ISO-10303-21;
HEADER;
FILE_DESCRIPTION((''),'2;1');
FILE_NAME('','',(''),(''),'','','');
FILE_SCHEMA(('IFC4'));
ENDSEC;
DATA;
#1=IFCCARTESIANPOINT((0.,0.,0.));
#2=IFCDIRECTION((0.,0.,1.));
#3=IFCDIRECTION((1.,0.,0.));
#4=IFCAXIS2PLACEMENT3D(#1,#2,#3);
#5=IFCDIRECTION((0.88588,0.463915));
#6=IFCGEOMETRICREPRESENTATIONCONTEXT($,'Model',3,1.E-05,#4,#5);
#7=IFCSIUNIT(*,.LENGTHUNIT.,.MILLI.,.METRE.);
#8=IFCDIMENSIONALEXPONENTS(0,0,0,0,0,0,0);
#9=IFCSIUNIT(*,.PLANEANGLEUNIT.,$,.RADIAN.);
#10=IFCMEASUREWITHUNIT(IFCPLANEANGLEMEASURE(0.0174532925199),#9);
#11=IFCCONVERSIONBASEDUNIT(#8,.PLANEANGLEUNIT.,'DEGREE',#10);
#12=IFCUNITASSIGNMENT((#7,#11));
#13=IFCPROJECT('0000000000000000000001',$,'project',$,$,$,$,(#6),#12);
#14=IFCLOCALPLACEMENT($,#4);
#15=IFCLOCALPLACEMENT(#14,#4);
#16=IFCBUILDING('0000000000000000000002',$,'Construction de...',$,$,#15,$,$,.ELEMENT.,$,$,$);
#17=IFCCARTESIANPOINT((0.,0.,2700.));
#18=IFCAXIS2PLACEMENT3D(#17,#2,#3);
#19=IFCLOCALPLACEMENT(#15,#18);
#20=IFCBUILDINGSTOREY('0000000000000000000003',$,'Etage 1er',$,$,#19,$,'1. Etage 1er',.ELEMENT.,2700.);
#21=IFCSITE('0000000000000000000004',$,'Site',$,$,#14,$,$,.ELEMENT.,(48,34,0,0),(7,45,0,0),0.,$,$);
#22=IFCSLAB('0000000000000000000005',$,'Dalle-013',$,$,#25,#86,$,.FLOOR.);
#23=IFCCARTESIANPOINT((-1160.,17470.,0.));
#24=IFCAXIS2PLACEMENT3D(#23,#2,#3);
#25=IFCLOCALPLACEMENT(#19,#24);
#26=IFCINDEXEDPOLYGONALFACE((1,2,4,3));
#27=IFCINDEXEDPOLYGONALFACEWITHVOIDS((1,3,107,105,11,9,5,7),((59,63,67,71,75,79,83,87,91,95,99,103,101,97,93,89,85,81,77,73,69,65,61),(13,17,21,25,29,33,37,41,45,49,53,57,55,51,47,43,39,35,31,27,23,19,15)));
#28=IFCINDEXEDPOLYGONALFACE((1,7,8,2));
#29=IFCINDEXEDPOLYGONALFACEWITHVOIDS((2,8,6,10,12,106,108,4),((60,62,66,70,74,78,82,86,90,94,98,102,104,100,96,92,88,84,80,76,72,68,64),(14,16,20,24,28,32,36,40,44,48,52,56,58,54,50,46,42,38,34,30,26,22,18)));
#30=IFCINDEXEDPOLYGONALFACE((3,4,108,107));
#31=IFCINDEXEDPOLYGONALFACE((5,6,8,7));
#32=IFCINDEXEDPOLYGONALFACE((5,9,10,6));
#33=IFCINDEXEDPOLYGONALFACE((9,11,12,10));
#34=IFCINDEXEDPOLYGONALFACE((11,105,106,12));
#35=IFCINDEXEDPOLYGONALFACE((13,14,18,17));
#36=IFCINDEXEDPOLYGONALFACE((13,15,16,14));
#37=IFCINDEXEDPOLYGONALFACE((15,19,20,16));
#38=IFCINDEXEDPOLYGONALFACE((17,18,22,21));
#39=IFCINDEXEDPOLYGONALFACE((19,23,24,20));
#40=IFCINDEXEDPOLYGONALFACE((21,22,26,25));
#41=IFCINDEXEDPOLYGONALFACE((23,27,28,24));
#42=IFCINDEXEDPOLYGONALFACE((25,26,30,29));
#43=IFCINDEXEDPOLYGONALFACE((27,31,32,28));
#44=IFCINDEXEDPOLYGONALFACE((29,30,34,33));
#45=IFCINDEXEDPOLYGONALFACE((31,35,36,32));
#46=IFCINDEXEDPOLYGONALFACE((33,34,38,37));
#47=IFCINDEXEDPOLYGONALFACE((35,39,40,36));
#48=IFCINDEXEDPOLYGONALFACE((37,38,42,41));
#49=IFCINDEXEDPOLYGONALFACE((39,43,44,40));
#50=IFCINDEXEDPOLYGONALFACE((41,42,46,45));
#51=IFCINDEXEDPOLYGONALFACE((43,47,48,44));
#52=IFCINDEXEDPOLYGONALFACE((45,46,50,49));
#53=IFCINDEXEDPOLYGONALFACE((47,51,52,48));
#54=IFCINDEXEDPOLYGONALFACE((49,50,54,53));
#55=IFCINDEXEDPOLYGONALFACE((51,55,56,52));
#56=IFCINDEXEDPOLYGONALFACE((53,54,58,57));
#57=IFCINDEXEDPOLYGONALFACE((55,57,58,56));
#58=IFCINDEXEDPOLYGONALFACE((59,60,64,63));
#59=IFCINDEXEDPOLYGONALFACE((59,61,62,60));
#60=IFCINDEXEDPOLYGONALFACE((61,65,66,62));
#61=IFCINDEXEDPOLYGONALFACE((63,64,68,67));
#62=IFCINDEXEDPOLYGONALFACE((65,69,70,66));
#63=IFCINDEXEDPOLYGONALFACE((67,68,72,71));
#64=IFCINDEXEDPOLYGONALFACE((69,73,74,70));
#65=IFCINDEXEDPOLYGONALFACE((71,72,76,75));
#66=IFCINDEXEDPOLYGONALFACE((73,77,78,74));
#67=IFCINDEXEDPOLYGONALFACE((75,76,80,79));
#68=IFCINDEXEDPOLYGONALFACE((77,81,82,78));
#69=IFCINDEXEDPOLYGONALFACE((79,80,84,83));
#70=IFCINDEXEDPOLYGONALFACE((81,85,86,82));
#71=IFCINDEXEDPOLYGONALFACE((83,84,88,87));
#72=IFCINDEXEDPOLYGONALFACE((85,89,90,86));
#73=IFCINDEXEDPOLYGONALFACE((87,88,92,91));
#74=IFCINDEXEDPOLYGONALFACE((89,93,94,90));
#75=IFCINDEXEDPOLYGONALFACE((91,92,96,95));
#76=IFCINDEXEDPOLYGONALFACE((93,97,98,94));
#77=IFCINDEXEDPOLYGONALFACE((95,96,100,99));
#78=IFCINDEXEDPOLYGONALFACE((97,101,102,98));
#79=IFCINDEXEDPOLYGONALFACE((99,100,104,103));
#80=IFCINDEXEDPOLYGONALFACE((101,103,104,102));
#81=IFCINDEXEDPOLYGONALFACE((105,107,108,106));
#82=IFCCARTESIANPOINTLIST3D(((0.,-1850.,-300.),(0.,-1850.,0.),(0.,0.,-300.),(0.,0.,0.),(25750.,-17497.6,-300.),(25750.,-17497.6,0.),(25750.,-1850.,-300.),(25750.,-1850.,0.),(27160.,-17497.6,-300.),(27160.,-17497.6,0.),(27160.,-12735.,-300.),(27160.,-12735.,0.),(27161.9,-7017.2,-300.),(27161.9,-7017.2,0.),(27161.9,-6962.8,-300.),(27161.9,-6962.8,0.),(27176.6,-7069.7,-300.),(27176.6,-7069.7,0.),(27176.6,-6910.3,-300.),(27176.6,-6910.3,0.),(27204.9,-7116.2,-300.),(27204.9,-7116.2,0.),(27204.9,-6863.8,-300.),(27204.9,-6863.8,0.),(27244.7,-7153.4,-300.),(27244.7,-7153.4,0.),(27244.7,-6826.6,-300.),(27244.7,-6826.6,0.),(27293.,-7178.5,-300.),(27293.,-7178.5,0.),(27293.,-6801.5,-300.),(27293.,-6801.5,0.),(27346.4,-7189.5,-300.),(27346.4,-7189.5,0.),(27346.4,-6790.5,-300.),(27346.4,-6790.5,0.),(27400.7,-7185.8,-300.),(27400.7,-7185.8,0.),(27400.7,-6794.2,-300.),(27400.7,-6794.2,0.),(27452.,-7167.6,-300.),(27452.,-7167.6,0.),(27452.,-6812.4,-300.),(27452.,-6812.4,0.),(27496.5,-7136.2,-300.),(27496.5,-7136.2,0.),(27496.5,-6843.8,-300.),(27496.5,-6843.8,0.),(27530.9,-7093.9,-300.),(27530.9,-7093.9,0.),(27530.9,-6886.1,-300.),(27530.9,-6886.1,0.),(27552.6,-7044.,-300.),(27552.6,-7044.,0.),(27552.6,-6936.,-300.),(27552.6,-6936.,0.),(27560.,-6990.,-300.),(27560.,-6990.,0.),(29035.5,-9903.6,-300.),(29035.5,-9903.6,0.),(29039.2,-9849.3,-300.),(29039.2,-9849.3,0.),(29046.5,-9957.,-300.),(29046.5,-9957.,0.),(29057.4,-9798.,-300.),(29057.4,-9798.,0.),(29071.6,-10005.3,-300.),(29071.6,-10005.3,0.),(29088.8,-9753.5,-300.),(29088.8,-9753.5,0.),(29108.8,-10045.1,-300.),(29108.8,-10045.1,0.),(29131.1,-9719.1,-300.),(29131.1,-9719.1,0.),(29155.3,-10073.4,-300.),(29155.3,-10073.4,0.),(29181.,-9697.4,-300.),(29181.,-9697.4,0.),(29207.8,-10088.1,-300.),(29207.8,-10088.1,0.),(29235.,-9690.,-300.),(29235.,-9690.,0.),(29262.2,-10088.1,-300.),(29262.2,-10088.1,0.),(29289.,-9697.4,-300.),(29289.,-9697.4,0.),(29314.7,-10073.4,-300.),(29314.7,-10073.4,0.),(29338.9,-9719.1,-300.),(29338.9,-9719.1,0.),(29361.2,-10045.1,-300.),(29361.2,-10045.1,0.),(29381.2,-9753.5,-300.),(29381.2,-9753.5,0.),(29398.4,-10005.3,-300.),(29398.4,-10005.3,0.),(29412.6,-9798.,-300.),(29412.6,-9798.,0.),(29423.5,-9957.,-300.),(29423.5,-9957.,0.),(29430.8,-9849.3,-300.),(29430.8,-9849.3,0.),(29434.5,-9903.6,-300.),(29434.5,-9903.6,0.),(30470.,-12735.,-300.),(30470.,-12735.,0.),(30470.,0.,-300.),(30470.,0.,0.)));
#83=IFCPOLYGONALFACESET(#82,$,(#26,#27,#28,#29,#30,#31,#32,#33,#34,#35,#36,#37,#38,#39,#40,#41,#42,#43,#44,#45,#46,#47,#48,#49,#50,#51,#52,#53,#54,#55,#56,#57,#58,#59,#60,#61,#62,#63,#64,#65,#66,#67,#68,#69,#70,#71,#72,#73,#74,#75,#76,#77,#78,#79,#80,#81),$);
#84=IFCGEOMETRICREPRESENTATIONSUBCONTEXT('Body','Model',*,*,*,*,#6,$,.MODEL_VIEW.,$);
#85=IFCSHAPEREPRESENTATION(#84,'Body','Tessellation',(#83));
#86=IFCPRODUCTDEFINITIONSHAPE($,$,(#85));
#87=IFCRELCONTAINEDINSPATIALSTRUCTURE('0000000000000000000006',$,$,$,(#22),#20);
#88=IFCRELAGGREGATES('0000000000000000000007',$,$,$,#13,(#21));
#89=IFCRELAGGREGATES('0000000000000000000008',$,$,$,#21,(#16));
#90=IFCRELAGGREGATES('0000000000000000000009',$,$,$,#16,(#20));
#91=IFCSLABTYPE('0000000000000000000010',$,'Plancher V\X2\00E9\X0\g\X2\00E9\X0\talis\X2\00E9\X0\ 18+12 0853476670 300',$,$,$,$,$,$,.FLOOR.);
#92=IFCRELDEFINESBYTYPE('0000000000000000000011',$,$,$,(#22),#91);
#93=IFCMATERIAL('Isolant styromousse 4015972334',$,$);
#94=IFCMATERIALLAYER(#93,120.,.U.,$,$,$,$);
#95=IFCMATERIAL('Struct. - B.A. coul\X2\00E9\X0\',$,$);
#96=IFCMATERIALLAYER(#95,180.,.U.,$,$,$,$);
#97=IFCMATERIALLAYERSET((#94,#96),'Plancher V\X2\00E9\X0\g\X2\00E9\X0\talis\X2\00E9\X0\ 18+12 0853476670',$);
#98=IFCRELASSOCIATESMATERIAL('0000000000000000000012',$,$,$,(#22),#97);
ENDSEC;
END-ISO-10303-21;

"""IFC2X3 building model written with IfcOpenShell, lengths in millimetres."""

from ifc_helpers import new_model, entity, si_unit, converted_unit, point, direction, frame, frame_2d, origin_with_axes, place, context, subcontext, project, spatial, polyline, circle_curve, parameter, trimmed, segment, composite_curve, outline, extrude, material, layer, layer_set, layer_usage, type_object, element, save


model = new_model("IFC2X3")

# Units and contexts
model_context = context("Model", 3, precision=1e-05, world=origin_with_axes(), true_north=direction((0.88588, 0.463915)))
body_context = subcontext(model_context, "Body", "Model", "MODEL_VIEW")
ifc_project = project(units=[si_unit("LENGTHUNIT", "METRE", prefix="MILLI"), converted_unit("PLANEANGLEUNIT", "DEGREE", entity("IfcPlaneAngleMeasure", 0.0174532925199), si_unit("PLANEANGLEUNIT", "RADIAN"), dimensions=[0, 0, 0, 0, 0, 0, 0])], contexts=[model_context])

# Site, building, storey
site_placement = place(None, origin_with_axes())
site = spatial("IfcSite", under=ifc_project, at=site_placement, Name="Site", CompositionType="ELEMENT", RefLatitude=(48, 34, 0, 0), RefLongitude=(7, 45, 0, 0), RefElevation=0.0)
building_placement = place(site_placement, origin_with_axes())
building = spatial("IfcBuilding", under=site, at=building_placement, Name="Construction de...", CompositionType="ELEMENT")
storey_placement = place(building_placement, frame((0.0, 0.0, 2700.0), z_axis=(0.0, 0.0, 1.0), x_axis=(1.0, 0.0, 0.0)))
storey = spatial("IfcBuildingStorey", under=building, at=storey_placement, Name="Etage 1er", LongName="1. Etage 1er", CompositionType="ELEMENT", Elevation=2700.0)

# Slab, openings
ifc_material_1 = material(Name="Isolant styromousse 4015972334")
ifc_layer_1 = layer(ifc_material_1, 120.0, ventilated="UNKNOWN")
ifc_material_2 = material(Name="Struct. - B.A. coulé")
ifc_layer_2 = layer(ifc_material_2, 180.0, ventilated="UNKNOWN")
ifc_layer_set_1 = layer_set([ifc_layer_1, ifc_layer_2], Name="Plancher Végétalisé 18+12 0853476670")
ifc_layer_usage_1 = layer_usage(ifc_layer_set_1, "AXIS3", "NEGATIVE", 300.0)
slab_type_1 = type_object("IfcSlabType", Name="Plancher Végétalisé 18+12 0853476670 300", PredefinedType="FLOOR")
slab_1_placement = place(storey_placement, frame((-1160.0, 17470.0, 0.0), z_axis=(0.0, 0.0, 1.0), x_axis=(1.0, 0.0, 0.0)))
slab_1 = element("IfcSlab", 1, at=slab_1_placement, inside=storey, type_object=slab_type_1, material=ifc_layer_usage_1, Name="Dalle-013", PredefinedType="FLOOR", context=body_context, shape_type="SweptSolid", body=[
    extrude(outline(polyline([(0.0, 0.0), (0.0, -1850.0), (25750.0, -1850.0), (25750.0, -17497.6), (27160.0, -17497.6), (27160.0, -12735.0), (30470.0, -12735.0), (30470.0, 0.0), (0.0, 0.0)])), frame((0.0, 0.0, -300.0), z_axis=(0.0, 0.0, 1.0), x_axis=(1.0, 0.0, 0.0)), (0.0, 0.0, 1.0), 300.0),
])
opening_1_placement = place(slab_1_placement, origin_with_axes())
element("IfcOpeningElement", 2, at=opening_1_placement, cuts=slab_1, context=body_context, shape_type="SweptSolid", body=[
    extrude(outline(composite_curve([segment(trimmed(circle_curve(frame_2d((27360.0, -6990.0), x_axis=(1.0, 0.0)), 200.0), [point((27560.0, -6990.0)), parameter(0.0)], [point((27360.0, -6790.0)), parameter(90.0)], True, "CARTESIAN"), True, "CONTINUOUS"), segment(trimmed(circle_curve(frame_2d((27360.0, -6990.0), x_axis=(0.0, 1.0)), 200.0), [point((27360.0, -6790.0)), parameter(0.0)], [point((27160.0, -6990.0)), parameter(90.0)], True, "CARTESIAN"), True, "CONTINUOUS"), segment(trimmed(circle_curve(frame_2d((27360.0, -6990.0), x_axis=(-1.0, 0.0)), 200.0), [point((27160.0, -6990.0)), parameter(0.0)], [point((27560.0, -6990.0)), parameter(180.0)], True, "CARTESIAN"), True, "CONTINUOUS")], self_intersect=False)), frame((0.0, 0.0, -300.0), z_axis=(0.0, 0.0, 1.0), x_axis=(1.0, 0.0, 0.0)), (0.0, 0.0, 1.0), 300.0),
])
opening_2_placement = place(slab_1_placement, origin_with_axes())
element("IfcOpeningElement", 3, at=opening_2_placement, cuts=slab_1, context=body_context, shape_type="SweptSolid", body=[
    extrude(outline(composite_curve([segment(trimmed(circle_curve(frame_2d((29235.0, -9890.0), x_axis=(-1.0, 0.0)), 200.0), [point((29035.0, -9890.0)), parameter(0.0)], [point((29435.0, -9890.0)), parameter(180.0)], True, "CARTESIAN"), True, "CONTINUOUS"), segment(trimmed(circle_curve(frame_2d((29235.0, -9890.0), x_axis=(1.0, 0.0)), 200.0), [point((29435.0, -9890.0)), parameter(0.0)], [point((29235.0, -9690.0)), parameter(90.0)], True, "CARTESIAN"), True, "CONTINUOUS"), segment(trimmed(circle_curve(frame_2d((29235.0, -9890.0), x_axis=(0.0, 1.0)), 200.0), [point((29235.0, -9690.0)), parameter(0.0)], [point((29035.0, -9890.0)), parameter(90.0)], True, "CARTESIAN"), True, "CONTINUOUS")], self_intersect=False)), frame((0.0, 0.0, -300.0), z_axis=(0.0, 0.0, 1.0), x_axis=(1.0, 0.0, 0.0)), (0.0, 0.0, 1.0), 300.0),
])

save(model, "model.ifc")
